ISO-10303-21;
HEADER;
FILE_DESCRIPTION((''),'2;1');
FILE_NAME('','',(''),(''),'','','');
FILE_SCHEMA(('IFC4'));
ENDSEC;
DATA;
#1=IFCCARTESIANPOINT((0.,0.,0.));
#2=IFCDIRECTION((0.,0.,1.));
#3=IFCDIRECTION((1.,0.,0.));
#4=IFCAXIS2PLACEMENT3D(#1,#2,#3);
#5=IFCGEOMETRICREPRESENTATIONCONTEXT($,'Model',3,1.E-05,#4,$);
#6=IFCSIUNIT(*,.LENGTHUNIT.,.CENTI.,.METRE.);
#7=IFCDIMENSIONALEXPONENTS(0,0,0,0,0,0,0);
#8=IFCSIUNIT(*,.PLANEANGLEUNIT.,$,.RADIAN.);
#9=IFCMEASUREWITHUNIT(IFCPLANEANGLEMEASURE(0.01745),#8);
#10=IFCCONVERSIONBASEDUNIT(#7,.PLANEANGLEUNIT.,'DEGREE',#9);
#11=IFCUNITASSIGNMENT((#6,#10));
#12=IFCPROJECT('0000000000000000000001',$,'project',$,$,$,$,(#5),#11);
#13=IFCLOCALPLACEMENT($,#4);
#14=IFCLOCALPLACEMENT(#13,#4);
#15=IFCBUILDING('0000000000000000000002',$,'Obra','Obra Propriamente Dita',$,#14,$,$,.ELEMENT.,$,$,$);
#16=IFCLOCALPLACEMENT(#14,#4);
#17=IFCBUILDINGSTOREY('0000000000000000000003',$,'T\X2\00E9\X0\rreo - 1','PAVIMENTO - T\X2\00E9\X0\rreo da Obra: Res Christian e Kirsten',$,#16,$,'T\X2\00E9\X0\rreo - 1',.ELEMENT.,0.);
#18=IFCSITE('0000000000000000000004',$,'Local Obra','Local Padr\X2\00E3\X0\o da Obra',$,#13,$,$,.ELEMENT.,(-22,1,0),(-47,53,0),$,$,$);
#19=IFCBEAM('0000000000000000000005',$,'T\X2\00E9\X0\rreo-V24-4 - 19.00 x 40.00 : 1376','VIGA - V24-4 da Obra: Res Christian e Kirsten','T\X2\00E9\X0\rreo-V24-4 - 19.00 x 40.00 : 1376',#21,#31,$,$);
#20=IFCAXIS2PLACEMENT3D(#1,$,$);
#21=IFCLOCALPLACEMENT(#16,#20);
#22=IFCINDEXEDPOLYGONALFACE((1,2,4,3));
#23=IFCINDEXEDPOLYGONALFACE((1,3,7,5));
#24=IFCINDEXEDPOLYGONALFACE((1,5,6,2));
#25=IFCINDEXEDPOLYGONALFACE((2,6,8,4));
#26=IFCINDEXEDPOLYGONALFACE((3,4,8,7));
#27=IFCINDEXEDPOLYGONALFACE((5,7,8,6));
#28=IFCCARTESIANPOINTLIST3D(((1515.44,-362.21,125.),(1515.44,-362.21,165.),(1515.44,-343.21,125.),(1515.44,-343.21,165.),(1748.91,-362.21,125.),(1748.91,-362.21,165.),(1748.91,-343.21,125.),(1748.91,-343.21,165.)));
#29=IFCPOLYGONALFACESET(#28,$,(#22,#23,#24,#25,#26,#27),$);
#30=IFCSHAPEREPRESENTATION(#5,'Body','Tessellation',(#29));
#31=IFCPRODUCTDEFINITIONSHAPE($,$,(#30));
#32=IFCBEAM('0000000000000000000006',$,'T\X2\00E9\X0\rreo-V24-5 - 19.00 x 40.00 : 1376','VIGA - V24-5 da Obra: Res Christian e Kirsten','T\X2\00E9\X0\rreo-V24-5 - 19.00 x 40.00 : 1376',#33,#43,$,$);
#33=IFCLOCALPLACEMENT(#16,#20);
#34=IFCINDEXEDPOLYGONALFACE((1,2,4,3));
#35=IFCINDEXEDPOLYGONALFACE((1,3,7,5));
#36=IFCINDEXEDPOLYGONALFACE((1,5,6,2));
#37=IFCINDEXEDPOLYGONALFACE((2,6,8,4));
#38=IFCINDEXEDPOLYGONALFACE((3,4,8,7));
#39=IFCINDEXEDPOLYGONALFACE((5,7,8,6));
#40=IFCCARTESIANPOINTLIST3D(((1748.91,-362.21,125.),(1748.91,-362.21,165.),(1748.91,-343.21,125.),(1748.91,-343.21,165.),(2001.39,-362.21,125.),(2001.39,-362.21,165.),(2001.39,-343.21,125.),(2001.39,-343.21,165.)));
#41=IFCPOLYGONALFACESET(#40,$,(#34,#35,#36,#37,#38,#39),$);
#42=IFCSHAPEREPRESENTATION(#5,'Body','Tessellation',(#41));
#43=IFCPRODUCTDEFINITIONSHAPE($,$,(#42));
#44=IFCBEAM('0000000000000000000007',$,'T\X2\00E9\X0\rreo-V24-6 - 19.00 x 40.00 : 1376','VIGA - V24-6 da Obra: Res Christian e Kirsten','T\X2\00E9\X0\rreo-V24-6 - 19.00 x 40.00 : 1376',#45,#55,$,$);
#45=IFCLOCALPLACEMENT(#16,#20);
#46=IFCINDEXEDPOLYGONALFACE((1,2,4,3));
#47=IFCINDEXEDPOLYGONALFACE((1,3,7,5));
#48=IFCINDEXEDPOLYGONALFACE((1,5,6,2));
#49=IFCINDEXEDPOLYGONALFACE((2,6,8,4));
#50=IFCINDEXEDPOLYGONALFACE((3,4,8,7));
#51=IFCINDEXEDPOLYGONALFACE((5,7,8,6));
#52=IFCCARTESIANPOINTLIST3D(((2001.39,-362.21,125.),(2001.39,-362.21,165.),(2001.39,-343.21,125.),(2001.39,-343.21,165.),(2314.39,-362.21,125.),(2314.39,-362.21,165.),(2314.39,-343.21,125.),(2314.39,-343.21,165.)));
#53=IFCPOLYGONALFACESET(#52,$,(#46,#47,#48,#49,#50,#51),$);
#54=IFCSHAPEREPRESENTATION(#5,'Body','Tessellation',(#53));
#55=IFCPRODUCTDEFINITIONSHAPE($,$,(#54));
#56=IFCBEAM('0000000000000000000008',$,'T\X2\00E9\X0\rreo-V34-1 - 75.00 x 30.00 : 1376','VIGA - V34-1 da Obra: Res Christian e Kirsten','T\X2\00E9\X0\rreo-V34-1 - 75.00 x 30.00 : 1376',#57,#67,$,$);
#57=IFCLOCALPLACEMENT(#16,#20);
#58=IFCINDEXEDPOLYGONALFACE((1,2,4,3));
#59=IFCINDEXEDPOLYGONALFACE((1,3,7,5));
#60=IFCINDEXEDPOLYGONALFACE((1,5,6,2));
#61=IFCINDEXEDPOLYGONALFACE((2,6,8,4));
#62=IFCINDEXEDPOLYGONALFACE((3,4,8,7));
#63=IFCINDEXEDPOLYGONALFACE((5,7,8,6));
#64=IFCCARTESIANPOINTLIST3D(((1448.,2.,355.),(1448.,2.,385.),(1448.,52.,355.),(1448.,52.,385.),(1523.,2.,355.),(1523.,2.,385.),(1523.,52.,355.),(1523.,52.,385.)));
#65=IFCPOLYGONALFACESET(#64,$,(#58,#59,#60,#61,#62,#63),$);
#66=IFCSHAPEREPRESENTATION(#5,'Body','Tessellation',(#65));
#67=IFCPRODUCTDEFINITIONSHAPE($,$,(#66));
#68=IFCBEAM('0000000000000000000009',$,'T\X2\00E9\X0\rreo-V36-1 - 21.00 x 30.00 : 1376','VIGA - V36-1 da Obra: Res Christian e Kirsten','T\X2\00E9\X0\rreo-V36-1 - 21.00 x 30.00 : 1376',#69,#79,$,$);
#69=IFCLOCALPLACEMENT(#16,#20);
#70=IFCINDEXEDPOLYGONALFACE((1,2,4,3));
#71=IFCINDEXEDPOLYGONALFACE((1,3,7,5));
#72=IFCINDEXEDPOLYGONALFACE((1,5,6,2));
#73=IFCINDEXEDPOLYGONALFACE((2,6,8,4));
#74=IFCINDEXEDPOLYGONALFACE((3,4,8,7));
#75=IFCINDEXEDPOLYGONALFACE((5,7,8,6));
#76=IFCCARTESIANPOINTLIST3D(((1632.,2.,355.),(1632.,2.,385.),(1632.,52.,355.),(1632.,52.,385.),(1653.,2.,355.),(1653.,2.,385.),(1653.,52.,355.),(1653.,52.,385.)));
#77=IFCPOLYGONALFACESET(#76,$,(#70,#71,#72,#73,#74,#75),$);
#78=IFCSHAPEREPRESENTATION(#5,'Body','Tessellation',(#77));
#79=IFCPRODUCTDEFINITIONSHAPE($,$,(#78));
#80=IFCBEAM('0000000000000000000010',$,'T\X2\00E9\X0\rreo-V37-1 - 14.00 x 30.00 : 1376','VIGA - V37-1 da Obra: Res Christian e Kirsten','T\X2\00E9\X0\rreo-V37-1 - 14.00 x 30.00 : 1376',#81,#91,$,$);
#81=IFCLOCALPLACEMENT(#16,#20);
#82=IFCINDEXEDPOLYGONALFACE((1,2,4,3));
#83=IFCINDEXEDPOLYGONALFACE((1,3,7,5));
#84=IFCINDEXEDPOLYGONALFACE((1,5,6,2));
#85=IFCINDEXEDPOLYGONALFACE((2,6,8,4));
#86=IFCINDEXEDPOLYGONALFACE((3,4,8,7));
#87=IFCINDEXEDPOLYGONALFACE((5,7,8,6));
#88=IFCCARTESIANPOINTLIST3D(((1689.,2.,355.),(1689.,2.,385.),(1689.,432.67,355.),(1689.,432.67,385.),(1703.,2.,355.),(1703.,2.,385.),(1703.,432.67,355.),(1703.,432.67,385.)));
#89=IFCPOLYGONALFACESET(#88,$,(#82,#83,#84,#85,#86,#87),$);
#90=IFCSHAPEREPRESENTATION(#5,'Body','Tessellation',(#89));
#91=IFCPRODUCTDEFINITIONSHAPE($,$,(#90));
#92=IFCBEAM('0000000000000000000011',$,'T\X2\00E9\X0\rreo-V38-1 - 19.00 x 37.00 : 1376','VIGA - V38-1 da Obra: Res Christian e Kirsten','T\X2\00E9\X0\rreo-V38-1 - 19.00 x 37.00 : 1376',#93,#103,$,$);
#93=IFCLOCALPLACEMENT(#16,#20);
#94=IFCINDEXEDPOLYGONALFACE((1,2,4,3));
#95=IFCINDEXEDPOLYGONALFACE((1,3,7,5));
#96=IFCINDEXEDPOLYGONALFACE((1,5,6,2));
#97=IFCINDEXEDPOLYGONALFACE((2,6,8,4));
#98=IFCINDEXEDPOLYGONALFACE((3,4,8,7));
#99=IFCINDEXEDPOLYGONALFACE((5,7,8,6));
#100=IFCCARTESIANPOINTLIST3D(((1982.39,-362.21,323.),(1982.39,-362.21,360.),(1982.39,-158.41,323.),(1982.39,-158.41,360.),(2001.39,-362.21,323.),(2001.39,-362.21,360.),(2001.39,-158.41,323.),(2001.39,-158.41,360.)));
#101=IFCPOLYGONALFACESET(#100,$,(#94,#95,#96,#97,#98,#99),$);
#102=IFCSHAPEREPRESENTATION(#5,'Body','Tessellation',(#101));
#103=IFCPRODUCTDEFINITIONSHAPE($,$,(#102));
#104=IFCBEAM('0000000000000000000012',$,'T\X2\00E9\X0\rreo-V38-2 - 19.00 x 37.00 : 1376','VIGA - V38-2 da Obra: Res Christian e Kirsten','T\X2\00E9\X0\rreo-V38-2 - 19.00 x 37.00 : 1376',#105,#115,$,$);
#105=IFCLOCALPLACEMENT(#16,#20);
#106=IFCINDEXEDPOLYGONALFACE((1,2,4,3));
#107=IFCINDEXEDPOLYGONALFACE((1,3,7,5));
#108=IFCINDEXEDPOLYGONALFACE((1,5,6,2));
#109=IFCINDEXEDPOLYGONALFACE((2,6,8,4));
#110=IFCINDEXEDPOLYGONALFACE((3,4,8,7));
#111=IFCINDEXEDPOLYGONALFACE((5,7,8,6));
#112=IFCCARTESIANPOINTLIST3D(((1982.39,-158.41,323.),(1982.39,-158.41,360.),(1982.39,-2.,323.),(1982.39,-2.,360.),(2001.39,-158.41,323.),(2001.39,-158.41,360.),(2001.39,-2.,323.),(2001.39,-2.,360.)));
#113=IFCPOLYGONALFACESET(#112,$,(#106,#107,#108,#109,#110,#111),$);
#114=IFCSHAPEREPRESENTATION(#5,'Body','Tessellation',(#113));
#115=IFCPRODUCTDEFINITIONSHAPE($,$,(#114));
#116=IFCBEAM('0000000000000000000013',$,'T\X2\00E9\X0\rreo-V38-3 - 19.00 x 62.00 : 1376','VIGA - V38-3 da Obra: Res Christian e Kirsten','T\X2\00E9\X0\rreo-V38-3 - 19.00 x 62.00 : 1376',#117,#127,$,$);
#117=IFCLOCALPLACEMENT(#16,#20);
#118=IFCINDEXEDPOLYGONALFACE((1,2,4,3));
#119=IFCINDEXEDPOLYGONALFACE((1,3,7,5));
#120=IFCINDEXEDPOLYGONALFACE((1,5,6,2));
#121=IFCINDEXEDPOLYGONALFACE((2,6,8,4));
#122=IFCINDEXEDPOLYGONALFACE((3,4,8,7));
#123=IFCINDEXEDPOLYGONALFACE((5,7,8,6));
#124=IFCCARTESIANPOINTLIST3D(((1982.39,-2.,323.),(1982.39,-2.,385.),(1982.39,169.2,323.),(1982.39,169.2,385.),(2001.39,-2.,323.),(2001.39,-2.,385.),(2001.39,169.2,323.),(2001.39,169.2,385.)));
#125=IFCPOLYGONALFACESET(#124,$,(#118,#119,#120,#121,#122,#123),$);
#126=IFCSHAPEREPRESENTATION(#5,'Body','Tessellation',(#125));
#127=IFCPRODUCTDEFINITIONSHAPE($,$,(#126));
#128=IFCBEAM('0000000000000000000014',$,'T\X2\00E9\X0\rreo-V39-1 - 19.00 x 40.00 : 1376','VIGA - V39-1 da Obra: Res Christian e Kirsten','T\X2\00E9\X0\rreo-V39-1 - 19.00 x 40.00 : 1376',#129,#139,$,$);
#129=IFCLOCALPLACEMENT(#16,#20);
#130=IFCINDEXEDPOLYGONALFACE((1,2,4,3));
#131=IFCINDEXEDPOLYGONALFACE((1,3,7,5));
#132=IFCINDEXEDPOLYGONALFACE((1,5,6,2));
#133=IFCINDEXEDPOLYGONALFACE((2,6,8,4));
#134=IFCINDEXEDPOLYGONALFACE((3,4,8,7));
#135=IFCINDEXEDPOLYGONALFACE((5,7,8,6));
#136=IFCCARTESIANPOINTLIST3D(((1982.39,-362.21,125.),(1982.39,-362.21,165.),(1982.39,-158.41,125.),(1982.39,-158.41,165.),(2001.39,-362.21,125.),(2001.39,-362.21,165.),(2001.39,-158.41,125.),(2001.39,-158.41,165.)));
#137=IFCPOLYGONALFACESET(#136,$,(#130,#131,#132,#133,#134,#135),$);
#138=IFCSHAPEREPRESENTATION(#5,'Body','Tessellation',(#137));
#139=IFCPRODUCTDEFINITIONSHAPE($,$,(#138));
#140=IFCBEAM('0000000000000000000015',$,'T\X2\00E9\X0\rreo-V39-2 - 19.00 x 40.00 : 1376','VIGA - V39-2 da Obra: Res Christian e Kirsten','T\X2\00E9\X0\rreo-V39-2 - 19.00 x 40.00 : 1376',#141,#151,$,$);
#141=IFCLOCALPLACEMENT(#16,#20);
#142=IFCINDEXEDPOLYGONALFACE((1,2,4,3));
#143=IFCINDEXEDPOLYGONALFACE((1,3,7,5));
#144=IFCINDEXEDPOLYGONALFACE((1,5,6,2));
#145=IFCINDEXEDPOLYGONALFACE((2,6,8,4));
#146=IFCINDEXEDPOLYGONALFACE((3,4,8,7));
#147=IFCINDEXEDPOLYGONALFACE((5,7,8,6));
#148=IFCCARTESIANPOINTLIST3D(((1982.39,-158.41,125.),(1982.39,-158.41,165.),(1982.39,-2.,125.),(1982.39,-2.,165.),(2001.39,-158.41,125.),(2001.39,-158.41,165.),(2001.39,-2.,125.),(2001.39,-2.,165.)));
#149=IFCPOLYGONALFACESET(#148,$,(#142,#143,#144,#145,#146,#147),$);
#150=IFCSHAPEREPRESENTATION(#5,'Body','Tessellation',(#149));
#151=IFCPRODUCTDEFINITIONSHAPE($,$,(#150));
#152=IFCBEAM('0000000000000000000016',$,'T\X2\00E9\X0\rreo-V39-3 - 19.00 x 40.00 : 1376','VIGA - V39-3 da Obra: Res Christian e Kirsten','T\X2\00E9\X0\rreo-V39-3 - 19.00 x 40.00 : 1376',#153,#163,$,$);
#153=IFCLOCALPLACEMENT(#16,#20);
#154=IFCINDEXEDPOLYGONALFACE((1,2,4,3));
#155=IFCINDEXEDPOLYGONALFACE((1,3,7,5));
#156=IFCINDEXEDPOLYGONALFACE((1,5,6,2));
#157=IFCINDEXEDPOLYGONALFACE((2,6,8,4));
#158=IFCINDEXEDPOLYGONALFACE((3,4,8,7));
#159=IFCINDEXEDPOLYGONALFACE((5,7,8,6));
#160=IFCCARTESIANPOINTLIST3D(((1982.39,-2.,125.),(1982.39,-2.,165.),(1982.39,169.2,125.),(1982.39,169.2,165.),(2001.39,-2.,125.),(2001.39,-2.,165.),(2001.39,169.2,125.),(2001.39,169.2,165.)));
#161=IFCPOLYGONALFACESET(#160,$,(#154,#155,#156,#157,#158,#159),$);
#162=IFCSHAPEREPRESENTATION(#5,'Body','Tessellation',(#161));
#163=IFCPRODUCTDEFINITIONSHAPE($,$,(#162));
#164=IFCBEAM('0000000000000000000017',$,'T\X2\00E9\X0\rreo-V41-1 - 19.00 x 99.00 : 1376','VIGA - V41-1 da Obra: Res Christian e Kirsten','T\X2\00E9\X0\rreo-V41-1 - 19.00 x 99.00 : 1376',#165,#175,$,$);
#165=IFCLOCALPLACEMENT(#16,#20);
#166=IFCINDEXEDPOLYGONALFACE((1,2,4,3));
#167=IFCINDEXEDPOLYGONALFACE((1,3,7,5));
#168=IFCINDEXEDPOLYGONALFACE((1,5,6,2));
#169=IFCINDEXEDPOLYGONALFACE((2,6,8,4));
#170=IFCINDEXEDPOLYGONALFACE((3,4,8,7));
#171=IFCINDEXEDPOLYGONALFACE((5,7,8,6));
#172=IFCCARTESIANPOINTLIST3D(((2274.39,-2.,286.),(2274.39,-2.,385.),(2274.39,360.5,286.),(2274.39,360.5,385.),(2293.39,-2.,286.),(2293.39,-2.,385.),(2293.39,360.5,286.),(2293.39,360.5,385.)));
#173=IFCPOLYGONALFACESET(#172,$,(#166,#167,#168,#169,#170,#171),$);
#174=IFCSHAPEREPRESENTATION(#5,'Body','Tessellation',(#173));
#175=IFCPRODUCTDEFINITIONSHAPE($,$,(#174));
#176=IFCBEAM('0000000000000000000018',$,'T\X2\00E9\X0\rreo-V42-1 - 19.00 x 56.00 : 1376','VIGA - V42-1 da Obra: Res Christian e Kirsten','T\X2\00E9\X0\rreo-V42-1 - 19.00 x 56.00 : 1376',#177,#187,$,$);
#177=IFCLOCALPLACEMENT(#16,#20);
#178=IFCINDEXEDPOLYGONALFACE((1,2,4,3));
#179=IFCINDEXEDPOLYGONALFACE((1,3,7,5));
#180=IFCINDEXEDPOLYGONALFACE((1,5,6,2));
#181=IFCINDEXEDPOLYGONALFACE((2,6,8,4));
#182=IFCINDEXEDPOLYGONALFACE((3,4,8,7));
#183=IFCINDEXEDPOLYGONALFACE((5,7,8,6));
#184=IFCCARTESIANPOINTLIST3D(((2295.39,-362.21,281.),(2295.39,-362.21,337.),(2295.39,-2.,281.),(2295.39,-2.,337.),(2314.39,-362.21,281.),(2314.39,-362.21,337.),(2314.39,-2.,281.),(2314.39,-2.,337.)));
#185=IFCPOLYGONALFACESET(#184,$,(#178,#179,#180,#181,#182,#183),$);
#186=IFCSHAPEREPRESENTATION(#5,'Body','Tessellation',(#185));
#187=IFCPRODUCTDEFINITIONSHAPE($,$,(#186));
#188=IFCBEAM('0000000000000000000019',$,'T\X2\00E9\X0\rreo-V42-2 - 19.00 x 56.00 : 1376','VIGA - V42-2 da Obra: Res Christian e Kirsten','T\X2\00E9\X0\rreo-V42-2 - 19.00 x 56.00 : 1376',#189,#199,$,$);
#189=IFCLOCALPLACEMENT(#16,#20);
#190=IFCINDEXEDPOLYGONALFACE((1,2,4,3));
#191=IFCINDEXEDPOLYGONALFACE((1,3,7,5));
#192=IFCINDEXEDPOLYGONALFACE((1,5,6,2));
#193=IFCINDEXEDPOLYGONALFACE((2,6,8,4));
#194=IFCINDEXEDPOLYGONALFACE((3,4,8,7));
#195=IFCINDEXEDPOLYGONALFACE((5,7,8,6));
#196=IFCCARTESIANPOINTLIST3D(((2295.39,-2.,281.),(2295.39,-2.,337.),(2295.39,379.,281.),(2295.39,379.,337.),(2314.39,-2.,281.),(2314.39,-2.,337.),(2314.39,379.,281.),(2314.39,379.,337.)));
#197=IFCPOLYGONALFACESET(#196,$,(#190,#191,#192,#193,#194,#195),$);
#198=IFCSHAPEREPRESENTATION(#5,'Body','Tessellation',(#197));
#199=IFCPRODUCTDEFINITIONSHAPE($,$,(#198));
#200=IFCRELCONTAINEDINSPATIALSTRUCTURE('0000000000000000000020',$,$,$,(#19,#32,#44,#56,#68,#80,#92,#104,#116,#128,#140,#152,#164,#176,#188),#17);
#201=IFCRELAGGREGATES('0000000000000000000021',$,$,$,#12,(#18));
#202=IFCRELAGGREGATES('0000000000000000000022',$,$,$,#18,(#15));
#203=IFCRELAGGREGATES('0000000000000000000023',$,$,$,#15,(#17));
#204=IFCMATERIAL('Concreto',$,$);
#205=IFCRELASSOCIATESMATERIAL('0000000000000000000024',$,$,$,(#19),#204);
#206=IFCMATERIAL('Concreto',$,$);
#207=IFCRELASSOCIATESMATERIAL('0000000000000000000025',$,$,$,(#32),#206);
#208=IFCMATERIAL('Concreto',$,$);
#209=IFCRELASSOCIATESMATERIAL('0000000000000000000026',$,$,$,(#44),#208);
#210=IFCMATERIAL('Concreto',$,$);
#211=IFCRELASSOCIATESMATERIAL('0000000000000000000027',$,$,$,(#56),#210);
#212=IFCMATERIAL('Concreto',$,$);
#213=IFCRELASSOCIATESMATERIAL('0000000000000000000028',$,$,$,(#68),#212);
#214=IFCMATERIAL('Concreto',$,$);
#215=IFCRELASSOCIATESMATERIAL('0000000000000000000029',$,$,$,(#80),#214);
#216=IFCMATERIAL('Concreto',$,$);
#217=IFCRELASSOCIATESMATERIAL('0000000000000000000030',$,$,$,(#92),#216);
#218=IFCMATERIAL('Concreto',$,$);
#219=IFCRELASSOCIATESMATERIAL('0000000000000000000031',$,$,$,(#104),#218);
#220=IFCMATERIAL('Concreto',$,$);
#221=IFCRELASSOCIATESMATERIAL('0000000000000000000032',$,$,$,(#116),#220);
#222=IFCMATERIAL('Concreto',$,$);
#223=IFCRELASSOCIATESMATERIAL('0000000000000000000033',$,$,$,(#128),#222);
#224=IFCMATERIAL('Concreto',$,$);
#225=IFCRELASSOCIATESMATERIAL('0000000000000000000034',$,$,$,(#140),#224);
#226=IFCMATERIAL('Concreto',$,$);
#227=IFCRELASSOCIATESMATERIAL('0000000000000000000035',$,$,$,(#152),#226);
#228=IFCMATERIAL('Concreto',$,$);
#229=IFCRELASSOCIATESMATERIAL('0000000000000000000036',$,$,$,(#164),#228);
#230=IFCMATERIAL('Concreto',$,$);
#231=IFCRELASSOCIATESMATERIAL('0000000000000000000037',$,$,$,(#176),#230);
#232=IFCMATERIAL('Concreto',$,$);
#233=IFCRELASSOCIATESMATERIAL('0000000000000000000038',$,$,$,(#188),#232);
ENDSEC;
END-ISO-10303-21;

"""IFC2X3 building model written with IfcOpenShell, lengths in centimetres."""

from ifc_helpers import new_model, entity, si_unit, converted_unit, frame, origin_with_axes, place, context, project, spatial, polyline, outline, extrude, material, element, save


model = new_model("IFC2X3")

# Units and contexts
model_context = context("Model", 3, precision=1e-05, world=origin_with_axes())
ifc_project = project(units=[si_unit("LENGTHUNIT", "METRE", prefix="CENTI"), converted_unit("PLANEANGLEUNIT", "DEGREE", entity("IfcPlaneAngleMeasure", 0.01745), si_unit("PLANEANGLEUNIT", "RADIAN"), dimensions=[0, 0, 0, 0, 0, 0, 0])], contexts=[model_context])

# Site, building, storey
site_placement = place(None, origin_with_axes())
site = spatial("IfcSite", under=ifc_project, at=site_placement, Name="Local Obra", Description="Local Padrão da Obra", CompositionType="ELEMENT", RefLatitude=(-22, 1, 0), RefLongitude=(-47, 53, 0))
building_placement = place(site_placement, origin_with_axes())
building = spatial("IfcBuilding", under=site, at=building_placement, Name="Obra", Description="Obra Propriamente Dita", CompositionType="ELEMENT")
storey_placement = place(building_placement, origin_with_axes())
storey = spatial("IfcBuildingStorey", under=building, at=storey_placement, Name="Térreo - 1", Description="PAVIMENTO - Térreo da Obra: Res Christian e Kirsten", LongName="Térreo - 1", CompositionType="ELEMENT", Elevation=0.0)

# Beams
ifc_material_1 = material(Name="Concreto")
beam_1_placement = place(storey_placement, frame((1515.44, -362.21, 165.0), z_axis=(1.0, 0.0, 0.0), x_axis=(0.0, -1.0, 0.0)))
element("IfcBeam", 1, at=beam_1_placement, inside=storey, material=ifc_material_1, Name="Térreo-V24-4 - 19.00 x 40.00 : 1376", Description="VIGA - V24-4 da Obra: Res Christian e Kirsten", ObjectType="Térreo-V24-4 - 19.00 x 40.00 : 1376", context=model_context, shape_type="SweptSolid", body=[
    extrude(outline(polyline([(-19.0, 0.0), (0.0, 0.0), (0.0, 40.0), (-19.0, 40.0), (-19.0, 0.0)])), origin_with_axes(), (0.0, 0.0, 1.0), 233.48),
])
ifc_material_2 = material(Name="Concreto")
beam_2_placement = place(storey_placement, frame((1748.91, -362.21, 165.0), z_axis=(1.0, 0.0, 0.0), x_axis=(0.0, -1.0, 0.0)))
element("IfcBeam", 2, at=beam_2_placement, inside=storey, material=ifc_material_2, Name="Térreo-V24-5 - 19.00 x 40.00 : 1376", Description="VIGA - V24-5 da Obra: Res Christian e Kirsten", ObjectType="Térreo-V24-5 - 19.00 x 40.00 : 1376", context=model_context, shape_type="SweptSolid", body=[
    extrude(outline(polyline([(-19.0, 0.0), (0.0, 0.0), (0.0, 40.0), (-19.0, 40.0), (-19.0, 0.0)])), origin_with_axes(), (0.0, 0.0, 1.0), 252.48),
])
ifc_material_3 = material(Name="Concreto")
beam_3_placement = place(storey_placement, frame((2001.39, -362.21, 165.0), z_axis=(1.0, 0.0, 0.0), x_axis=(0.0, -1.0, 0.0)))
element("IfcBeam", 3, at=beam_3_placement, inside=storey, material=ifc_material_3, Name="Térreo-V24-6 - 19.00 x 40.00 : 1376", Description="VIGA - V24-6 da Obra: Res Christian e Kirsten", ObjectType="Térreo-V24-6 - 19.00 x 40.00 : 1376", context=model_context, shape_type="SweptSolid", body=[
    extrude(outline(polyline([(-19.0, 0.0), (0.0, 0.0), (0.0, 40.0), (-19.0, 40.0), (-19.0, 0.0)])), origin_with_axes(), (0.0, 0.0, 1.0), 313.0),
])
ifc_material_4 = material(Name="Concreto")
beam_4_placement = place(storey_placement, frame((1523.0, 2.0, 385.0), z_axis=(0.0, 1.0, 0.0), x_axis=(1.0, 0.0, 0.0)))
element("IfcBeam", 4, at=beam_4_placement, inside=storey, material=ifc_material_4, Name="Térreo-V34-1 - 75.00 x 30.00 : 1376", Description="VIGA - V34-1 da Obra: Res Christian e Kirsten", ObjectType="Térreo-V34-1 - 75.00 x 30.00 : 1376", context=model_context, shape_type="SweptSolid", body=[
    extrude(outline(polyline([(-75.0, 0.0), (0.0, 0.0), (0.0, 30.0), (-75.0, 30.0), (-75.0, 0.0)])), origin_with_axes(), (0.0, 0.0, 1.0), 50.0),
])
ifc_material_5 = material(Name="Concreto")
beam_5_placement = place(storey_placement, frame((1653.0, 2.0, 385.0), z_axis=(0.0, 1.0, 0.0), x_axis=(1.0, 0.0, 0.0)))
element("IfcBeam", 5, at=beam_5_placement, inside=storey, material=ifc_material_5, Name="Térreo-V36-1 - 21.00 x 30.00 : 1376", Description="VIGA - V36-1 da Obra: Res Christian e Kirsten", ObjectType="Térreo-V36-1 - 21.00 x 30.00 : 1376", context=model_context, shape_type="SweptSolid", body=[
    extrude(outline(polyline([(-21.0, 0.0), (0.0, 0.0), (0.0, 30.0), (-21.0, 30.0), (-21.0, 0.0)])), origin_with_axes(), (0.0, 0.0, 1.0), 50.0),
])
ifc_material_6 = material(Name="Concreto")
beam_6_placement = place(storey_placement, frame((1703.0, 2.0, 385.0), z_axis=(0.0, 1.0, 0.0), x_axis=(1.0, 0.0, 0.0)))
element("IfcBeam", 6, at=beam_6_placement, inside=storey, material=ifc_material_6, Name="Térreo-V37-1 - 14.00 x 30.00 : 1376", Description="VIGA - V37-1 da Obra: Res Christian e Kirsten", ObjectType="Térreo-V37-1 - 14.00 x 30.00 : 1376", context=model_context, shape_type="SweptSolid", body=[
    extrude(outline(polyline([(-14.0, 0.0), (0.0, 0.0), (0.0, 30.0), (-14.0, 30.0), (-14.0, 0.0)])), origin_with_axes(), (0.0, 0.0, 1.0), 430.67),
])
ifc_material_7 = material(Name="Concreto")
beam_7_placement = place(storey_placement, frame((2001.39, -362.21, 360.0), z_axis=(0.0, 1.0, 0.0), x_axis=(1.0, 0.0, 0.0)))
element("IfcBeam", 7, at=beam_7_placement, inside=storey, material=ifc_material_7, Name="Térreo-V38-1 - 19.00 x 37.00 : 1376", Description="VIGA - V38-1 da Obra: Res Christian e Kirsten", ObjectType="Térreo-V38-1 - 19.00 x 37.00 : 1376", context=model_context, shape_type="SweptSolid", body=[
    extrude(outline(polyline([(-19.0, 0.0), (0.0, 0.0), (0.0, 37.0), (-19.0, 37.0), (-19.0, 0.0)])), origin_with_axes(), (0.0, 0.0, 1.0), 203.8),
])
ifc_material_8 = material(Name="Concreto")
beam_8_placement = place(storey_placement, frame((2001.39, -158.41, 360.0), z_axis=(0.0, 1.0, 0.0), x_axis=(1.0, 0.0, 0.0)))
element("IfcBeam", 8, at=beam_8_placement, inside=storey, material=ifc_material_8, Name="Térreo-V38-2 - 19.00 x 37.00 : 1376", Description="VIGA - V38-2 da Obra: Res Christian e Kirsten", ObjectType="Térreo-V38-2 - 19.00 x 37.00 : 1376", context=model_context, shape_type="SweptSolid", body=[
    extrude(outline(polyline([(-19.0, 0.0), (0.0, 0.0), (0.0, 37.0), (-19.0, 37.0), (-19.0, 0.0)])), origin_with_axes(), (0.0, 0.0, 1.0), 156.41),
])
ifc_material_9 = material(Name="Concreto")
beam_9_placement = place(storey_placement, frame((2001.39, -2.0, 385.0), z_axis=(0.0, 1.0, 0.0), x_axis=(1.0, 0.0, 0.0)))
element("IfcBeam", 9, at=beam_9_placement, inside=storey, material=ifc_material_9, Name="Térreo-V38-3 - 19.00 x 62.00 : 1376", Description="VIGA - V38-3 da Obra: Res Christian e Kirsten", ObjectType="Térreo-V38-3 - 19.00 x 62.00 : 1376", context=model_context, shape_type="SweptSolid", body=[
    extrude(outline(polyline([(-19.0, 0.0), (0.0, 0.0), (0.0, 62.0), (-19.0, 62.0), (-19.0, 0.0)])), origin_with_axes(), (0.0, 0.0, 1.0), 171.2),
])
ifc_material_10 = material(Name="Concreto")
beam_10_placement = place(storey_placement, frame((2001.39, -362.21, 165.0), z_axis=(0.0, 1.0, 0.0), x_axis=(1.0, 0.0, 0.0)))
element("IfcBeam", 10, at=beam_10_placement, inside=storey, material=ifc_material_10, Name="Térreo-V39-1 - 19.00 x 40.00 : 1376", Description="VIGA - V39-1 da Obra: Res Christian e Kirsten", ObjectType="Térreo-V39-1 - 19.00 x 40.00 : 1376", context=model_context, shape_type="SweptSolid", body=[
    extrude(outline(polyline([(-19.0, 0.0), (0.0, 0.0), (0.0, 40.0), (-19.0, 40.0), (-19.0, 0.0)])), origin_with_axes(), (0.0, 0.0, 1.0), 203.8),
])
ifc_material_11 = material(Name="Concreto")
beam_11_placement = place(storey_placement, frame((2001.39, -158.41, 165.0), z_axis=(0.0, 1.0, 0.0), x_axis=(1.0, 0.0, 0.0)))
element("IfcBeam", 11, at=beam_11_placement, inside=storey, material=ifc_material_11, Name="Térreo-V39-2 - 19.00 x 40.00 : 1376", Description="VIGA - V39-2 da Obra: Res Christian e Kirsten", ObjectType="Térreo-V39-2 - 19.00 x 40.00 : 1376", context=model_context, shape_type="SweptSolid", body=[
    extrude(outline(polyline([(-19.0, 0.0), (0.0, 0.0), (0.0, 40.0), (-19.0, 40.0), (-19.0, 0.0)])), origin_with_axes(), (0.0, 0.0, 1.0), 156.41),
])
ifc_material_12 = material(Name="Concreto")
beam_12_placement = place(storey_placement, frame((2001.39, -2.0, 165.0), z_axis=(0.0, 1.0, 0.0), x_axis=(1.0, 0.0, 0.0)))
element("IfcBeam", 12, at=beam_12_placement, inside=storey, material=ifc_material_12, Name="Térreo-V39-3 - 19.00 x 40.00 : 1376", Description="VIGA - V39-3 da Obra: Res Christian e Kirsten", ObjectType="Térreo-V39-3 - 19.00 x 40.00 : 1376", context=model_context, shape_type="SweptSolid", body=[
    extrude(outline(polyline([(-19.0, 0.0), (0.0, 0.0), (0.0, 40.0), (-19.0, 40.0), (-19.0, 0.0)])), origin_with_axes(), (0.0, 0.0, 1.0), 171.2),
])
ifc_material_13 = material(Name="Concreto")
beam_13_placement = place(storey_placement, frame((2293.39, -2.0, 385.0), z_axis=(0.0, 1.0, 0.0), x_axis=(1.0, 0.0, 0.0)))
element("IfcBeam", 13, at=beam_13_placement, inside=storey, material=ifc_material_13, Name="Térreo-V41-1 - 19.00 x 99.00 : 1376", Description="VIGA - V41-1 da Obra: Res Christian e Kirsten", ObjectType="Térreo-V41-1 - 19.00 x 99.00 : 1376", context=model_context, shape_type="SweptSolid", body=[
    extrude(outline(polyline([(-19.0, 0.0), (0.0, 0.0), (0.0, 99.0), (-19.0, 99.0), (-19.0, 0.0)])), origin_with_axes(), (0.0, 0.0, 1.0), 362.5),
])
ifc_material_14 = material(Name="Concreto")
beam_14_placement = place(storey_placement, frame((2314.39, -362.21, 337.0), z_axis=(0.0, 1.0, 0.0), x_axis=(1.0, 0.0, 0.0)))
element("IfcBeam", 14, at=beam_14_placement, inside=storey, material=ifc_material_14, Name="Térreo-V42-1 - 19.00 x 56.00 : 1376", Description="VIGA - V42-1 da Obra: Res Christian e Kirsten", ObjectType="Térreo-V42-1 - 19.00 x 56.00 : 1376", context=model_context, shape_type="SweptSolid", body=[
    extrude(outline(polyline([(-19.0, 0.0), (0.0, 0.0), (0.0, 56.0), (-19.0, 56.0), (-19.0, 0.0)])), origin_with_axes(), (0.0, 0.0, 1.0), 360.21),
])
ifc_material_15 = material(Name="Concreto")
beam_15_placement = place(storey_placement, frame((2314.39, -2.0, 337.0), z_axis=(-0.000003, 1.0, 0.0), x_axis=(1.0, 0.000003, 0.0)))
element("IfcBeam", 15, at=beam_15_placement, inside=storey, material=ifc_material_15, Name="Térreo-V42-2 - 19.00 x 56.00 : 1376", Description="VIGA - V42-2 da Obra: Res Christian e Kirsten", ObjectType="Térreo-V42-2 - 19.00 x 56.00 : 1376", context=model_context, shape_type="SweptSolid", body=[
    extrude(outline(polyline([(-19.0, 0.0), (0.0, 0.0), (0.0, 56.0), (-19.0, 56.0), (-19.0, 0.0)])), origin_with_axes(), (0.0, 0.0, 1.0), 381.0),
])

save(model, "model.ifc")
